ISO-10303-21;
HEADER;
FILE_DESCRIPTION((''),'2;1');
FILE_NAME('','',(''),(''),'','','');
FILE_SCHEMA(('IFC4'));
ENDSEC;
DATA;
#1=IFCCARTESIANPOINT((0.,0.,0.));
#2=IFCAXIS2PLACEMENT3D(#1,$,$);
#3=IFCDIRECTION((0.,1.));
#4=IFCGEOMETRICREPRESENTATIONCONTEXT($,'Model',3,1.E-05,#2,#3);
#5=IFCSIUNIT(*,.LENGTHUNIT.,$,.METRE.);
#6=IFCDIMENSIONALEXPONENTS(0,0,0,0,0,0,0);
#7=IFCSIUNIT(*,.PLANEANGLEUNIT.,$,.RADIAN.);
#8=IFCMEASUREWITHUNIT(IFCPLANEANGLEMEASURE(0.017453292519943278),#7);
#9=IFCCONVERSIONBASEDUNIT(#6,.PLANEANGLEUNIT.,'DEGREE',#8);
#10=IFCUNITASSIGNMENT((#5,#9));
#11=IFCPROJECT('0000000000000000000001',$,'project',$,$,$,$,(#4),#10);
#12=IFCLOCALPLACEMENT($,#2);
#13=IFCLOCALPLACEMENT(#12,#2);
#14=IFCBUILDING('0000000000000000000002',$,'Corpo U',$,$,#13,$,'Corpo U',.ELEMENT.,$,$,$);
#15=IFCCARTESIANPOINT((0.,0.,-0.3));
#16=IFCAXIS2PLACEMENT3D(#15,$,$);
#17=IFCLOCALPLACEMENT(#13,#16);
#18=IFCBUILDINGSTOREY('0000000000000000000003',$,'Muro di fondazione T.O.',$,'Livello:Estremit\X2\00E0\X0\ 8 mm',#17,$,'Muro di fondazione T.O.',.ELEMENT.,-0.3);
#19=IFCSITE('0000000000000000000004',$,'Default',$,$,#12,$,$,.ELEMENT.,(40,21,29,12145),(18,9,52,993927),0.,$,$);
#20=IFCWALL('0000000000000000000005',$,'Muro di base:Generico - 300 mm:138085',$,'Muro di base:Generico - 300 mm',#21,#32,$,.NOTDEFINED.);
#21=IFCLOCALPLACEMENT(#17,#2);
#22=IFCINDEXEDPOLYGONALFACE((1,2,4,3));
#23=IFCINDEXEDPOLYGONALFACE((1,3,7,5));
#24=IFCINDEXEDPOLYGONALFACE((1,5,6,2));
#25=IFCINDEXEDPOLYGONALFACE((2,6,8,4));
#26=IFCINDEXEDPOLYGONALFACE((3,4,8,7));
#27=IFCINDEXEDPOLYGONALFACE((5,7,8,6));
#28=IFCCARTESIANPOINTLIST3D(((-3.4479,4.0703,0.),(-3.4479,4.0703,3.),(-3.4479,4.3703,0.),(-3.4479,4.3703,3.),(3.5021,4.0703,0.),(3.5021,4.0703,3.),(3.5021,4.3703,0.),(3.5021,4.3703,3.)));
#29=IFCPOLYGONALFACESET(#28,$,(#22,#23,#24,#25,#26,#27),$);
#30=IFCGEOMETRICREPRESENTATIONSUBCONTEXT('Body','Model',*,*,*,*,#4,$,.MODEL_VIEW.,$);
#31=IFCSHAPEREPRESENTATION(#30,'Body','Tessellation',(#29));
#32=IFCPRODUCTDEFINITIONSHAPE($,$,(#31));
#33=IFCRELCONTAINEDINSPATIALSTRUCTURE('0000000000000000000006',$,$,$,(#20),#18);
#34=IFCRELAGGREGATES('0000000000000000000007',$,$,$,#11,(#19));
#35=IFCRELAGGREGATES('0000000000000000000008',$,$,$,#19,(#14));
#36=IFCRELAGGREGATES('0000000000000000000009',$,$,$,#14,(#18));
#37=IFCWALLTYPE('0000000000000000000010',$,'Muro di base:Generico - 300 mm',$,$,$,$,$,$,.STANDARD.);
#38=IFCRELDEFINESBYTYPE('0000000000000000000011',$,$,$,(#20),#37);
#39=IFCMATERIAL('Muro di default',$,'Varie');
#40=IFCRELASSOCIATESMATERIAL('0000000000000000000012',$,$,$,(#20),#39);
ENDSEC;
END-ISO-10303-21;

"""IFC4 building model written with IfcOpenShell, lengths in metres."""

from ifc_helpers import new_model, entity, si_unit, converted_unit, direction, frame, origin, place, context, subcontext, project, spatial, indexed_curve, outline, extrude, material, type_object, element, save


model = new_model("IFC4")

# Units and contexts
model_context = context("Model", 3, precision=1e-05, world=origin(), true_north=direction((0.0, 1.0)))
body_context = subcontext(model_context, "Body", "Model", "MODEL_VIEW")
ifc_project = project(units=[si_unit("LENGTHUNIT", "METRE"), converted_unit("PLANEANGLEUNIT", "DEGREE", entity("IfcPlaneAngleMeasure", 0.017453292519943278), si_unit("PLANEANGLEUNIT", "RADIAN"), dimensions=[0, 0, 0, 0, 0, 0, 0])], contexts=[model_context])

# Site, building, storey
site_placement = place(None, origin())
site = spatial("IfcSite", under=ifc_project, at=site_placement, Name="Default", CompositionType="ELEMENT", RefLatitude=(40, 21, 29, 12145), RefLongitude=(18, 9, 52, 993927), RefElevation=0.0)
building_placement = place(site_placement, origin())
building = spatial("IfcBuilding", under=site, at=building_placement, Name="Corpo U", LongName="Corpo U", CompositionType="ELEMENT")
storey_placement = place(building_placement, frame((0.0, 0.0, -0.3)))
storey = spatial("IfcBuildingStorey", under=building, at=storey_placement, Name="Muro di fondazione T.O.", ObjectType="Livello:Estremità 8 mm", LongName="Muro di fondazione T.O.", CompositionType="ELEMENT", Elevation=-0.3)

# Wall
ifc_material = material(Name="Muro di default", Category="Varie")
wall_type = type_object("IfcWallType", Name="Muro di base:Generico - 300 mm", PredefinedType="STANDARD")
wall_placement = place(storey_placement, frame((-3.4479, 4.2203, 0.0)))
element("IfcWall", 1, at=wall_placement, inside=storey, type_object=wall_type, material=ifc_material, Name="Muro di base:Generico - 300 mm:138085", ObjectType="Muro di base:Generico - 300 mm", PredefinedType="NOTDEFINED", context=body_context, shape_type="SweptSolid", body=[
    extrude(outline(indexed_curve([(6.95, 0.15), (0.0, 0.15), (0.0, -0.15), (6.95, -0.15), (6.95, 0.15)], self_intersect=False)), origin(), (0.0, 0.0, 1.0), 3.0),
])

save(model, "model.ifc")
